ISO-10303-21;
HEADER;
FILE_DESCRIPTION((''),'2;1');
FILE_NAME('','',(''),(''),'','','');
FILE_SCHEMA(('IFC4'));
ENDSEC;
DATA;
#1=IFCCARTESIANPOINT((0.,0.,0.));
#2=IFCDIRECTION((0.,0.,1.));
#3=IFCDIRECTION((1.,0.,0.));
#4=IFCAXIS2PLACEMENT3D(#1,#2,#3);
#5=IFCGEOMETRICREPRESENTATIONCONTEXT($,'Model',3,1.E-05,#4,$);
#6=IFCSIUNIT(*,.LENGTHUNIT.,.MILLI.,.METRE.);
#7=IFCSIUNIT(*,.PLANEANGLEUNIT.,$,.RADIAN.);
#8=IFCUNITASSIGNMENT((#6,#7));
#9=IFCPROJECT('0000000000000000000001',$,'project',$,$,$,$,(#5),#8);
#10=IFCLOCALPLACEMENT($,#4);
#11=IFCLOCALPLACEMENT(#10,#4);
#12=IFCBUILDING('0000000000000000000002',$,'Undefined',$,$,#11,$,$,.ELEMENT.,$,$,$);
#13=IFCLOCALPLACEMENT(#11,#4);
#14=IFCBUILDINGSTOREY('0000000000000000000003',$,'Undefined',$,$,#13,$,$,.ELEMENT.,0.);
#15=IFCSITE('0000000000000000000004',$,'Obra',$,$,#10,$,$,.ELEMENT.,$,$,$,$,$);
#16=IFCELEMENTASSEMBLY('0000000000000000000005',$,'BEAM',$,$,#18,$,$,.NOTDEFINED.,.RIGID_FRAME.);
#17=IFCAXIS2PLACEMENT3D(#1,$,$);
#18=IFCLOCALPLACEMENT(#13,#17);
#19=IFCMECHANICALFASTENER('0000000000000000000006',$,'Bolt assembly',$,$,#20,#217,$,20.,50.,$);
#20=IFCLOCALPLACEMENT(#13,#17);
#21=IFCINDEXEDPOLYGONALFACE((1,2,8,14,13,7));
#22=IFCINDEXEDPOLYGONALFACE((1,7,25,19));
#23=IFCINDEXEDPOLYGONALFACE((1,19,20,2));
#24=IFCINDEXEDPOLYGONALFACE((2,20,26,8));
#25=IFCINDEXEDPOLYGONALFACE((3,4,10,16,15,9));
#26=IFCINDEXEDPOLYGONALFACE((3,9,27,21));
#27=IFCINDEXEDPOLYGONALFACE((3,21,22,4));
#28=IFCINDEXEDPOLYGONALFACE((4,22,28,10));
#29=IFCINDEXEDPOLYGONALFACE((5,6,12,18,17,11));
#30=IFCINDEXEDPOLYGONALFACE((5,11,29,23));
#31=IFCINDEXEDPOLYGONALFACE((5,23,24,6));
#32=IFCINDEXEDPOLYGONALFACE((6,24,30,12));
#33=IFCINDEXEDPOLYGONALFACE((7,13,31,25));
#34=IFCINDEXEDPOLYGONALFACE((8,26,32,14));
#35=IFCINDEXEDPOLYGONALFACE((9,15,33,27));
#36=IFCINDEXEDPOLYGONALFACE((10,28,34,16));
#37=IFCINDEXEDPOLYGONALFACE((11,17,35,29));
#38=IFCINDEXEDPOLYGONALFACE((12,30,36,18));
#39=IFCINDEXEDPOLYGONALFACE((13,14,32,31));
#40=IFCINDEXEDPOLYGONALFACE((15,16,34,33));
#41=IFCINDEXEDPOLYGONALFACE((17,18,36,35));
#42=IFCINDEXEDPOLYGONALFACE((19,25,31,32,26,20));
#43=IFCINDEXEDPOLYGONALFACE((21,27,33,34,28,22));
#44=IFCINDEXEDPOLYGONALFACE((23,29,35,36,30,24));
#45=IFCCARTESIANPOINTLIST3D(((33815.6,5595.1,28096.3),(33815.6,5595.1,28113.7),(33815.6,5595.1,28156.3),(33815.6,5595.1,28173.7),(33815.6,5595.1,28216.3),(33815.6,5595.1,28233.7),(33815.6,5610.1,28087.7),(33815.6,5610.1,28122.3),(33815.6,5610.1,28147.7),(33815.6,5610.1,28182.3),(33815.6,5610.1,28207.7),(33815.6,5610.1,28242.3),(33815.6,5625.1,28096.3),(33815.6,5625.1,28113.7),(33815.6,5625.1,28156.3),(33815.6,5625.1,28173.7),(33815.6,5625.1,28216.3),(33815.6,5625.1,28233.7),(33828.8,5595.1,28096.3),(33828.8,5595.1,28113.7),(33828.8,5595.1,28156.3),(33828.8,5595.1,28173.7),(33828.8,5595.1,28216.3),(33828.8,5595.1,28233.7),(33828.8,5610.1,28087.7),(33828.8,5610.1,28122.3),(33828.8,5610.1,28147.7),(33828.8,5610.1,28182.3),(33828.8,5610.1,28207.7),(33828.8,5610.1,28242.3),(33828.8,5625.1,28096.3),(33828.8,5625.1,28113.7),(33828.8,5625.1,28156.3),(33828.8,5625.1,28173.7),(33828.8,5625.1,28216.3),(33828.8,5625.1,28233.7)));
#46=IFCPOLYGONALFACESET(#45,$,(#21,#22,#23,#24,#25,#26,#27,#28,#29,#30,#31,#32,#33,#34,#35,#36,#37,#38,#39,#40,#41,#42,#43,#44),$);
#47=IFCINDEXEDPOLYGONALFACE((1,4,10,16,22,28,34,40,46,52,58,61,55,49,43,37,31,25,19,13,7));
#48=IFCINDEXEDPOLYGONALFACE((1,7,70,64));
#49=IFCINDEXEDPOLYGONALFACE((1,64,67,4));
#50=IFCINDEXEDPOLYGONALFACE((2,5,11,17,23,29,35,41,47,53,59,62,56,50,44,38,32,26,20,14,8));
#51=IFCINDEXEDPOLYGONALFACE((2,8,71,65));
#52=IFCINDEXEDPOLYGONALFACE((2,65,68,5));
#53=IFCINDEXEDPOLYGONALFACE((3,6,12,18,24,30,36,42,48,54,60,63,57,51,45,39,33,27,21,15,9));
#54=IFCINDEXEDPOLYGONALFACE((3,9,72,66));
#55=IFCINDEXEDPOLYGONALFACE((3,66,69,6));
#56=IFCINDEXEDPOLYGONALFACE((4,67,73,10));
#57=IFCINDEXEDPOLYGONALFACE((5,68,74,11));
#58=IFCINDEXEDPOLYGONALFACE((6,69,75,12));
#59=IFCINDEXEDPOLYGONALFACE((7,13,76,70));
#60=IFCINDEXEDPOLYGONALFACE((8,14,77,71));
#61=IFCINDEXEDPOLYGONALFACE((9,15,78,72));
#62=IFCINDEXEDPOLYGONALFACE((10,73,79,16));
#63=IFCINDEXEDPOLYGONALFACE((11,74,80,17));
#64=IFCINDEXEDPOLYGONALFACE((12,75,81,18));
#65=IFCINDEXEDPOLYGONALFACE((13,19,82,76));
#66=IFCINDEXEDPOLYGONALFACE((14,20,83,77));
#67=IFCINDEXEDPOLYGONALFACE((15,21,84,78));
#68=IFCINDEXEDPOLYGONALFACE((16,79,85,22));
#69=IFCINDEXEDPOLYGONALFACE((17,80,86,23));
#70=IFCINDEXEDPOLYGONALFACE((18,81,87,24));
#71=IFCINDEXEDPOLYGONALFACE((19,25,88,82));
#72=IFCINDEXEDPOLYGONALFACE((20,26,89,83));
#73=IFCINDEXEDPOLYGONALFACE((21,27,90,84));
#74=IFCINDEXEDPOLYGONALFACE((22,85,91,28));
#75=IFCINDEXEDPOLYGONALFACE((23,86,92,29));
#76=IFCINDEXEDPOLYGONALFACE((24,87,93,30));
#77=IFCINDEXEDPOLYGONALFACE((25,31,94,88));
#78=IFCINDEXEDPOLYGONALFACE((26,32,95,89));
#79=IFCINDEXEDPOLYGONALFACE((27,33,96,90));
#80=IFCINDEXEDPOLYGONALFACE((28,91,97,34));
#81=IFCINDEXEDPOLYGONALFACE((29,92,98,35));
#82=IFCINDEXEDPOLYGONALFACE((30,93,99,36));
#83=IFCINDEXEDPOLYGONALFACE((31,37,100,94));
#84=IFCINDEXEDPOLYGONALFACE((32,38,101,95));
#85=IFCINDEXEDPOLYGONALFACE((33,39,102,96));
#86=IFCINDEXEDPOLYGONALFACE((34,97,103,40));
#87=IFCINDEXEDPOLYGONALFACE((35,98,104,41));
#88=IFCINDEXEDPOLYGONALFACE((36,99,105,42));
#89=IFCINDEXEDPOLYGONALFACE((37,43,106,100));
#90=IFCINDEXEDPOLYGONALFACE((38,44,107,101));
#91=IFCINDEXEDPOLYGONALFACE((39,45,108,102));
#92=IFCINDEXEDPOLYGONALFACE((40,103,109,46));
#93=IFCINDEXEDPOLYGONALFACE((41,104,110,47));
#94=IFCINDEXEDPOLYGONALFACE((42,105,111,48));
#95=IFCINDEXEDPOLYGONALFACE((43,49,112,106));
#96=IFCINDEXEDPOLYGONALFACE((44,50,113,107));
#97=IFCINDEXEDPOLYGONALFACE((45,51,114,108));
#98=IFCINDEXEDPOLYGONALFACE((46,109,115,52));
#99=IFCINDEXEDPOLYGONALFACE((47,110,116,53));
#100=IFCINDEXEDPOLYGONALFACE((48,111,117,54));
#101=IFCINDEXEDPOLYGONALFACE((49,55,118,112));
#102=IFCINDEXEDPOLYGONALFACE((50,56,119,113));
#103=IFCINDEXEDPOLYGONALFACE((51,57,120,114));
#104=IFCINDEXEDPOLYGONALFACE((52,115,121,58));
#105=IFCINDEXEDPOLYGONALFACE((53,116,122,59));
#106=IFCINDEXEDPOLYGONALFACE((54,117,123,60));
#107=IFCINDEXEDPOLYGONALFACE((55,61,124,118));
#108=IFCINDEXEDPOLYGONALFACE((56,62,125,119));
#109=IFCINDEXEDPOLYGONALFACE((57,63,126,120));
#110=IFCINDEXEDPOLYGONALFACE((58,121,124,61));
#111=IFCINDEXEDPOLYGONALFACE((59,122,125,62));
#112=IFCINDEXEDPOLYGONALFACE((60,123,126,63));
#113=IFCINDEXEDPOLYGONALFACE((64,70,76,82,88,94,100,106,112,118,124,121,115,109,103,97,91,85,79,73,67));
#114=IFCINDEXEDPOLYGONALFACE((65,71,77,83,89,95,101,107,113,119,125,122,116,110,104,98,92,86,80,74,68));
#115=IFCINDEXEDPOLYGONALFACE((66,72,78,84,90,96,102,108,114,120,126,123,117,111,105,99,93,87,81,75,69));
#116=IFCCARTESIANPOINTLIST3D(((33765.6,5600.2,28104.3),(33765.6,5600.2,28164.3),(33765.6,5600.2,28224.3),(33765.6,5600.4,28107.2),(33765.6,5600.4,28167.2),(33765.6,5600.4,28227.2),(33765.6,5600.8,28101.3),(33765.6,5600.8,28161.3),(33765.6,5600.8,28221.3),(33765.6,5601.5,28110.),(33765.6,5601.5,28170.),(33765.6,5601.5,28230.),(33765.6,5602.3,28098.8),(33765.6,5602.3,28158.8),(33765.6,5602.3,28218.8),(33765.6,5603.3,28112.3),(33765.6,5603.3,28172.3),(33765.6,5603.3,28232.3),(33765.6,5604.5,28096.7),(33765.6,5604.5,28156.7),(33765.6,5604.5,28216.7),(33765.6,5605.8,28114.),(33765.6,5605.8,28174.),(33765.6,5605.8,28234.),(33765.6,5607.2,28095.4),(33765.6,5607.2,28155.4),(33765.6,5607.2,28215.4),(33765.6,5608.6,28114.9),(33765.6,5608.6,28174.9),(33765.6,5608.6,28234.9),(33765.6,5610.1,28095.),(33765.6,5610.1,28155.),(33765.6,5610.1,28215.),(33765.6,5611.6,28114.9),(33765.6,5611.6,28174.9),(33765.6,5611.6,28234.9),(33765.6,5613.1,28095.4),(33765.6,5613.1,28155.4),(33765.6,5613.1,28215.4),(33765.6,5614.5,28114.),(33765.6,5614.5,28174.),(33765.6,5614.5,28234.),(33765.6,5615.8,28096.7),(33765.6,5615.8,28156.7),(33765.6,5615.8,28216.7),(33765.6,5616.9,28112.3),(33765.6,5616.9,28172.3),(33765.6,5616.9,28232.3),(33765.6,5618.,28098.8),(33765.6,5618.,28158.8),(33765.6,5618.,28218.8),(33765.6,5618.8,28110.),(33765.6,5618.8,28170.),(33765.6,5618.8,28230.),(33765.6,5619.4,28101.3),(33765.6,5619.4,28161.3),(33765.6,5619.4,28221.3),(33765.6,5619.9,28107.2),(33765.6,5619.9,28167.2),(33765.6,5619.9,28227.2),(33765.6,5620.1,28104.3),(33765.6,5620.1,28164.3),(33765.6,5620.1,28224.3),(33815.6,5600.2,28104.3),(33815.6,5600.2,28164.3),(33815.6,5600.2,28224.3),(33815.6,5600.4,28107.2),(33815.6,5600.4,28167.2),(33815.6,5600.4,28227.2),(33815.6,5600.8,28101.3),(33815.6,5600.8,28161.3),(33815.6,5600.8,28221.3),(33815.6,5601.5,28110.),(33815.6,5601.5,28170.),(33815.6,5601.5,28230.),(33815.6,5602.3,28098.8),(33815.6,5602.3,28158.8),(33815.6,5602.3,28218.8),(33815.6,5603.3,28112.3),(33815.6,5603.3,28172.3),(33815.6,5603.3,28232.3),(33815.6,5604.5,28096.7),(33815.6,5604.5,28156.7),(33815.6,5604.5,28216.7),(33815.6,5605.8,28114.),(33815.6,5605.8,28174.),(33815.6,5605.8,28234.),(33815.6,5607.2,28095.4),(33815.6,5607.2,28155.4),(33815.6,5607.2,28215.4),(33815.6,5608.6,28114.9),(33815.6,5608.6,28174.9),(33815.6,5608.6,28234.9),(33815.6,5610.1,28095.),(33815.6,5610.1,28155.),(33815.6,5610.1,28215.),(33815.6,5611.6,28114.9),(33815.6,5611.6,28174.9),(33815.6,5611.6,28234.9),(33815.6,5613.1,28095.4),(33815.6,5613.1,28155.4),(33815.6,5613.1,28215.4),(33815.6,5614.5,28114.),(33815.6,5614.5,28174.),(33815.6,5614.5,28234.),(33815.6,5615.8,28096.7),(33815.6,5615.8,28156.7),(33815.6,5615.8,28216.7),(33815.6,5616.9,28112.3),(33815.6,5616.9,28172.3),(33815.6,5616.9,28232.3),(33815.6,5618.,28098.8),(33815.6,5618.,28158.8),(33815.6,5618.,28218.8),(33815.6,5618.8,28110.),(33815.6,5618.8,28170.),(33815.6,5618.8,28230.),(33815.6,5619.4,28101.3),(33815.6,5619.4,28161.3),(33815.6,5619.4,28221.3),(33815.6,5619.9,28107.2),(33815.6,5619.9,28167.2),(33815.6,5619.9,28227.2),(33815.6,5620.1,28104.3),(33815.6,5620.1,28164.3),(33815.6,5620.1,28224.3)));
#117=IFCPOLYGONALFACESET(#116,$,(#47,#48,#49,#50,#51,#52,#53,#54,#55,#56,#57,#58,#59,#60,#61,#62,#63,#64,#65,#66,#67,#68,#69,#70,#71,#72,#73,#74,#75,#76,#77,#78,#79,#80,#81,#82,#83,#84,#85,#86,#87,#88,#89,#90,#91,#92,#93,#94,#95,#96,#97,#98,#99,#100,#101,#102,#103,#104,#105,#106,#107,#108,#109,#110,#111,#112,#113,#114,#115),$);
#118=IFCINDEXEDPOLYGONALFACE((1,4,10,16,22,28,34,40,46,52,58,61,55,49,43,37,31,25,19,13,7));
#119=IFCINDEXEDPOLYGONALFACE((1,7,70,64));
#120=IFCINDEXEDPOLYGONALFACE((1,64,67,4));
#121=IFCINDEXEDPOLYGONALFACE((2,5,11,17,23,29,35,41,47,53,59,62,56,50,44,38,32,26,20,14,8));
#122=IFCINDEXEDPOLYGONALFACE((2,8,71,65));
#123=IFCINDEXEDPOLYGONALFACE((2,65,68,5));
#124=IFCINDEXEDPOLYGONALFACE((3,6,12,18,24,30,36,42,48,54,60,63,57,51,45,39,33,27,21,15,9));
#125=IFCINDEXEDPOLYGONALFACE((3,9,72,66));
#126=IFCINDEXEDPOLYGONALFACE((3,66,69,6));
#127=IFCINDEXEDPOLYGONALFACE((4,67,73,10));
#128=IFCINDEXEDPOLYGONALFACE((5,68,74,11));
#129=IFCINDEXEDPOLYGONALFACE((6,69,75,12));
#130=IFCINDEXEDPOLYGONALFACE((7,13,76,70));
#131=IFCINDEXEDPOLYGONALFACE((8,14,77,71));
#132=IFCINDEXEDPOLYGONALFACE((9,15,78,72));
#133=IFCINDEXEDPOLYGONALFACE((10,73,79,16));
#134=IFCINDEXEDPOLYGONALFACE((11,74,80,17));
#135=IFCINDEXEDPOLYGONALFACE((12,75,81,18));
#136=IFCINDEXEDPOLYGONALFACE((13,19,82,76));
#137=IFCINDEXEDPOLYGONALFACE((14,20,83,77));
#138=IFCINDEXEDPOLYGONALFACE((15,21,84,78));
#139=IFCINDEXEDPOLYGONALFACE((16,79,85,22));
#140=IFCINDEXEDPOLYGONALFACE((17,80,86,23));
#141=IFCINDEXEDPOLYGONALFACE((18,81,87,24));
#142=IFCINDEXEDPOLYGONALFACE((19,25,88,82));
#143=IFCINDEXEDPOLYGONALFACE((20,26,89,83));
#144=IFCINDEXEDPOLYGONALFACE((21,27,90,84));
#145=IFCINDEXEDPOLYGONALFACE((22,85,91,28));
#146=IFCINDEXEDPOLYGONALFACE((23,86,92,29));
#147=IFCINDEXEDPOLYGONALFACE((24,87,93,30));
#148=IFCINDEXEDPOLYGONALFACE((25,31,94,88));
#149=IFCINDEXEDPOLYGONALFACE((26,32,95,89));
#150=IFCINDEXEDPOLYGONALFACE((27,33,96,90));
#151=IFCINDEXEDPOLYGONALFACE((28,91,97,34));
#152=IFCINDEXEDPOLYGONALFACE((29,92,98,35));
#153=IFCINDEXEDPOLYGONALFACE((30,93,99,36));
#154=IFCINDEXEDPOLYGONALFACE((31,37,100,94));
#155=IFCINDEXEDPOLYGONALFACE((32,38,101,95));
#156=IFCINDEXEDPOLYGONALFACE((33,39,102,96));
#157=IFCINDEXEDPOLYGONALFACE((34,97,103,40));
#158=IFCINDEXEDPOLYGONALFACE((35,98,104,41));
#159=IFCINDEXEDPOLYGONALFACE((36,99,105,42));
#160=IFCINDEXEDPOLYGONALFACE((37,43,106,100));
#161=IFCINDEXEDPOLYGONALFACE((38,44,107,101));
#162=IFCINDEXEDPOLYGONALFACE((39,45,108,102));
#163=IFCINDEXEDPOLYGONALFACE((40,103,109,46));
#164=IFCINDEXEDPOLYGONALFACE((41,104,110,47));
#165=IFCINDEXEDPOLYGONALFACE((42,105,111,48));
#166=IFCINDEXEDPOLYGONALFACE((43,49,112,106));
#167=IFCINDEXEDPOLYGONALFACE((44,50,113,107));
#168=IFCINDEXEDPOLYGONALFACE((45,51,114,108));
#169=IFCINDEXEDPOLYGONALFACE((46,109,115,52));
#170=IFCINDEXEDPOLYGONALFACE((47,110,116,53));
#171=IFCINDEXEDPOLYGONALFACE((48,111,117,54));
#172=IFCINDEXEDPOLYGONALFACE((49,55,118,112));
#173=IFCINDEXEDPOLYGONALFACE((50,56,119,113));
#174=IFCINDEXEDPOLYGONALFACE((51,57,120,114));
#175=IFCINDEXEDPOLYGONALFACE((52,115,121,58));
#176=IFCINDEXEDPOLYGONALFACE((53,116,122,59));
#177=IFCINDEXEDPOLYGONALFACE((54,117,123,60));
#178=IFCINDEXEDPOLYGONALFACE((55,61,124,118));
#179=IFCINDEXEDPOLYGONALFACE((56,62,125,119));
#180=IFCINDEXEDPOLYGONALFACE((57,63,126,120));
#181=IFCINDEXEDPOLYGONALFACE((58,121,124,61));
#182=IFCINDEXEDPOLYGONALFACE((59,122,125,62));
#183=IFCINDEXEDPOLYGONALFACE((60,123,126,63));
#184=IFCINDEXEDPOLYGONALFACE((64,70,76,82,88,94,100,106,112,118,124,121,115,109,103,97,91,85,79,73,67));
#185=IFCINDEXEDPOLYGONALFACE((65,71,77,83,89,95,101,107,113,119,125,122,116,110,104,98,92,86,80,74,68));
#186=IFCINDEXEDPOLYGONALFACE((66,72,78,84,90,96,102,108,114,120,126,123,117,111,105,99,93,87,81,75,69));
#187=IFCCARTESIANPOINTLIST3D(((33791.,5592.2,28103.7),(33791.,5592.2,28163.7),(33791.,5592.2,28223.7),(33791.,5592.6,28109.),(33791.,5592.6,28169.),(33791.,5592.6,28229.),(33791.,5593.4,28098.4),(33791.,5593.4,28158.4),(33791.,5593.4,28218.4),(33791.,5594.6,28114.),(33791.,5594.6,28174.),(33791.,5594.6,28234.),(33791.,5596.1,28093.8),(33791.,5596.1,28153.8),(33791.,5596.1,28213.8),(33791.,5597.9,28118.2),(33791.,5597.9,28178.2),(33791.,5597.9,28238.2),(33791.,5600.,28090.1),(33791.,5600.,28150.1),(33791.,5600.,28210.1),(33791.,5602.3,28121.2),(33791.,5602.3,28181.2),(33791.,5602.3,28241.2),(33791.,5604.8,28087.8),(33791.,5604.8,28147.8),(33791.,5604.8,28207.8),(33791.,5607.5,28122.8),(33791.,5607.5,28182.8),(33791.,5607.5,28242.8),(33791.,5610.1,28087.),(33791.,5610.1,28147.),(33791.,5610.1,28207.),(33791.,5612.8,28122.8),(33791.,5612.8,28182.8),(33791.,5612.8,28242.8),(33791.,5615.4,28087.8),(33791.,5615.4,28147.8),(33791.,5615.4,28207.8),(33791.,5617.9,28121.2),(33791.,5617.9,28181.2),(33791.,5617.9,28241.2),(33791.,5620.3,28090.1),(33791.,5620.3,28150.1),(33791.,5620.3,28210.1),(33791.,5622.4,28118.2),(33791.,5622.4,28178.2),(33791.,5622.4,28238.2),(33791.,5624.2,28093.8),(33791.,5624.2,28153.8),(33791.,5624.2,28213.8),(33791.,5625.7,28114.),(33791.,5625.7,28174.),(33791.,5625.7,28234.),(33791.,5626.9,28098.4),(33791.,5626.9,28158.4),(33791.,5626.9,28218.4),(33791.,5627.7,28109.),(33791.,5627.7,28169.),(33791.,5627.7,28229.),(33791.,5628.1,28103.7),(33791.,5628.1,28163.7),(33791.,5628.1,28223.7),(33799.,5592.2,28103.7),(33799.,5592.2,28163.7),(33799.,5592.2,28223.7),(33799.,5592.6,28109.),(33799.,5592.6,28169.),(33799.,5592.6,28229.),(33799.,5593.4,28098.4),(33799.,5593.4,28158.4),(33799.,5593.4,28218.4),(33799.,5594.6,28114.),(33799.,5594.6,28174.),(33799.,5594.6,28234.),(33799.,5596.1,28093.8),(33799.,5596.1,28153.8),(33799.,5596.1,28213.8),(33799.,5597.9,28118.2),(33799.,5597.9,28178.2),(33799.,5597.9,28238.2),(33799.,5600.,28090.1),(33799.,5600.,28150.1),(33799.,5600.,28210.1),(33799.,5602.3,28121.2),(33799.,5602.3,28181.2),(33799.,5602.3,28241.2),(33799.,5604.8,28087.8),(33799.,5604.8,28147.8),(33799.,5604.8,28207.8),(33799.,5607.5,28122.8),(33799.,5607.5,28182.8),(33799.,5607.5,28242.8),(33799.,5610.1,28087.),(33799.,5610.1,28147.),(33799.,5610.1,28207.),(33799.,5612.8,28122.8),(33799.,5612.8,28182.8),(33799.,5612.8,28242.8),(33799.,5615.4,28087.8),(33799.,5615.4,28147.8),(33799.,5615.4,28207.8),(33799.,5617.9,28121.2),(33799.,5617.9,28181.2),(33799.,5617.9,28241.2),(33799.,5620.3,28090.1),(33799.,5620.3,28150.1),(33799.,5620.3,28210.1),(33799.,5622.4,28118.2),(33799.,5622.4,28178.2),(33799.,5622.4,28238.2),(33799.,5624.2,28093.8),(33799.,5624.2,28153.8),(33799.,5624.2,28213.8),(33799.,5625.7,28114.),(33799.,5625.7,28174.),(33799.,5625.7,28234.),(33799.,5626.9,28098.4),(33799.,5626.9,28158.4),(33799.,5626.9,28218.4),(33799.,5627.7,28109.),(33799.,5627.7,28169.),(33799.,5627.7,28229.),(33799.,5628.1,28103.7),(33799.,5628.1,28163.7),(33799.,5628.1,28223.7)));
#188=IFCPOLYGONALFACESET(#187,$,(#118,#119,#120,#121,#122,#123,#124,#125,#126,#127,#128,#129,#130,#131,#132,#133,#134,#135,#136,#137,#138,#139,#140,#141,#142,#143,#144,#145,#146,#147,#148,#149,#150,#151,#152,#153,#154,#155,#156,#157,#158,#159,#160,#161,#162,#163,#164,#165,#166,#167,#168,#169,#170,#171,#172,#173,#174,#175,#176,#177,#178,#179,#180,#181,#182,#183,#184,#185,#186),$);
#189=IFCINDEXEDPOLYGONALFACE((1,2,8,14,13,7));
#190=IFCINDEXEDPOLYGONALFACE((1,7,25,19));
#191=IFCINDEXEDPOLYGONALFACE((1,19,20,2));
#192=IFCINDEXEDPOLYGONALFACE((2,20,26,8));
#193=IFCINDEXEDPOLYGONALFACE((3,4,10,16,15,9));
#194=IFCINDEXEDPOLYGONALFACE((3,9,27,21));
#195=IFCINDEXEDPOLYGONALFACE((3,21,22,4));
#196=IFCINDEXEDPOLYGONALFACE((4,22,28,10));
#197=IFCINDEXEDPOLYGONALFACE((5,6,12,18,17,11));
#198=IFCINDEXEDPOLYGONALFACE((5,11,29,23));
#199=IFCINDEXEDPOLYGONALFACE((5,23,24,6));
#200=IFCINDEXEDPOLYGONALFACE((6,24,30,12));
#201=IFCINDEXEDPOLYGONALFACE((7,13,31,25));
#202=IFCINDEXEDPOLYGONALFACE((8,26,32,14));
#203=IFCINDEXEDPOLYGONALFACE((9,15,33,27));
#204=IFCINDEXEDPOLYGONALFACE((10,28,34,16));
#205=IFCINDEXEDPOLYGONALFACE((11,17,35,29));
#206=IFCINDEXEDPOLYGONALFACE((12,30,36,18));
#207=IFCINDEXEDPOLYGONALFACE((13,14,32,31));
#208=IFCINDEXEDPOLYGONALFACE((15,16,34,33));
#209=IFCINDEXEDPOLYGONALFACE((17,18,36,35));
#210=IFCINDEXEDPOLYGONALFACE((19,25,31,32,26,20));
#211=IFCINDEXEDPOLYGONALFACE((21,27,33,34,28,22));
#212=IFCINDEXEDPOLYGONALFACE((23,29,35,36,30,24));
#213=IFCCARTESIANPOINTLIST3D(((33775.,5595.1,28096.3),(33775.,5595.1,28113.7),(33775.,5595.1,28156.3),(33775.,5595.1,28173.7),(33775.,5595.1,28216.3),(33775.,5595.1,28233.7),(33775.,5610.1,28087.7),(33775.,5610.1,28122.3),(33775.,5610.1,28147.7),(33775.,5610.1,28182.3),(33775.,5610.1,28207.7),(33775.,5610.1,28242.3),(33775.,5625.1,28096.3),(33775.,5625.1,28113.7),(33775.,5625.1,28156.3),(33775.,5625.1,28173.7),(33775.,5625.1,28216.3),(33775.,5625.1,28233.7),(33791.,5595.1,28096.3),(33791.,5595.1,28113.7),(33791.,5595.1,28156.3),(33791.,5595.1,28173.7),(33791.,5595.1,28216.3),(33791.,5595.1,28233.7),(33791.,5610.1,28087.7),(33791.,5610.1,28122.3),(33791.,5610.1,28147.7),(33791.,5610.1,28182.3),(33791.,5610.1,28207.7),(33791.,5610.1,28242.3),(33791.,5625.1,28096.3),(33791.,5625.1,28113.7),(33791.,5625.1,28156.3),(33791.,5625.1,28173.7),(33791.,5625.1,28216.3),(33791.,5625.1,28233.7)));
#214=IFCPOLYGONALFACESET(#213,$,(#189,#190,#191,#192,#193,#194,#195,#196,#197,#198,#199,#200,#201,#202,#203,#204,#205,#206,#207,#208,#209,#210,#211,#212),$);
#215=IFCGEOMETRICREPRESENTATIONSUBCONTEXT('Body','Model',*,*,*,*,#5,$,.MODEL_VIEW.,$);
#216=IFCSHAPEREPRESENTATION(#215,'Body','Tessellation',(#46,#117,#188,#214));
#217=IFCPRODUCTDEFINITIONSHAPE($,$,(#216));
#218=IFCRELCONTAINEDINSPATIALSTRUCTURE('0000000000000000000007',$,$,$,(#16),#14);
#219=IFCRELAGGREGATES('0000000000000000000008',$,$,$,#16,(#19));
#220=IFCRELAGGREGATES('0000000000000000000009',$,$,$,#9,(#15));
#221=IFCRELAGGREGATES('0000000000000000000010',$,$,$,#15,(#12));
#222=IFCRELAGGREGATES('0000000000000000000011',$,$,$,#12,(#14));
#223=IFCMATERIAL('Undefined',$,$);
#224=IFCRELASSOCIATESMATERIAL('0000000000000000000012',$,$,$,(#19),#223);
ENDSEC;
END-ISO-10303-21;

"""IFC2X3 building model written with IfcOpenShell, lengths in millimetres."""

from ifc_helpers import new_model, si_unit, frame, origin_with_axes, origin_2d_with_axis, place, context, subcontext, project, spatial, polyline, circle, outline, extrude, source, transform, mapped, material, element, aggregate, save


model = new_model("IFC2X3")

# Units and contexts
model_context = context("Model", 3, precision=1e-05, world=origin_with_axes())
body_context = subcontext(model_context, "Body", "Model", "MODEL_VIEW")
ifc_project = project(units=[si_unit("LENGTHUNIT", "METRE", prefix="MILLI"), si_unit("PLANEANGLEUNIT", "RADIAN")], contexts=[model_context])

# Site, building, storey
site_placement = place(None, origin_with_axes())
site = spatial("IfcSite", under=ifc_project, at=site_placement, Name="Obra", CompositionType="ELEMENT")
building_placement = place(site_placement, origin_with_axes())
building = spatial("IfcBuilding", under=site, at=building_placement, Name="Undefined", CompositionType="ELEMENT")
storey_placement = place(building_placement, origin_with_axes())
storey = spatial("IfcBuildingStorey", under=building, at=storey_placement, Name="Undefined", CompositionType="ELEMENT", Elevation=0.0)

# Shared definitions
ifc_material_1 = material(Name="Undefined")

# Element assembly, mechanical fastener
shared_shape_1 = source(origin_with_axes(), body_context, "Body", "SweptSolid", [
    extrude(outline(polyline([(17.3, 0.0), (8.7, 15.0), (-8.7, 15.0), (-17.3, 0.0), (-8.7, -15.0), (8.7, -15.0), (17.3, 0.0)])), frame((0.0, -26.5, 0.0), z_axis=(0.0, 1.0, 0.0), x_axis=(1.0, 0.0, 0.0)), (0.0, 0.0, 1.0), 13.2),
    extrude(circle(Radius=10.0, at=origin_2d_with_axis()), frame((0.0, -13.3, 0.0), z_axis=(0.0, 1.0, 0.0), x_axis=(1.0, 0.0, 0.0)), (0.0, 0.0, 1.0), 50.0),
    extrude(circle(Radius=18.0, at=origin_2d_with_axis()), frame((0.0, 3.3, 0.0), z_axis=(0.0, 1.0, 0.0), x_axis=(1.0, 0.0, 0.0)), (0.0, 0.0, 1.0), 8.0),
    extrude(outline(polyline([(17.3, 0.0), (8.7, 15.0), (-8.7, 15.0), (-17.3, 0.0), (-8.7, -15.0), (8.7, -15.0), (17.3, 0.0)])), frame((0.0, 11.3, 0.0), z_axis=(0.0, 1.0, 0.0), x_axis=(1.0, 0.0, 0.0)), (0.0, 0.0, 1.0), 16.0),
])
assembly_1_placement = place(storey_placement, origin_with_axes())
assembly_1 = element("IfcElementAssembly", 1, at=assembly_1_placement, inside=storey, Name="BEAM", AssemblyPlace="NOTDEFINED", PredefinedType="RIGID_FRAME")
mechanical_fastener_1_placement = place(assembly_1_placement, frame((33802.3, 5560.1, 28265.0), z_axis=(0.0, 1.0, 0.0), x_axis=(0.0, 0.0, -1.0)))
mechanical_fastener_1 = element("IfcMechanicalFastener", 2, at=mechanical_fastener_1_placement, material=ifc_material_1, Name="Bolt assembly", NominalDiameter=20.0, NominalLength=50.0, context=body_context, shape_type="MappedRepresentation", body=[
    mapped(shared_shape_1, transform((40.0, 0.0, 50.0))),
    mapped(shared_shape_1, transform((100.0, 0.0, 50.0))),
    mapped(shared_shape_1, transform((160.0, 0.0, 50.0))),
])
aggregate(assembly_1, [mechanical_fastener_1])

save(model, "model.ifc")
